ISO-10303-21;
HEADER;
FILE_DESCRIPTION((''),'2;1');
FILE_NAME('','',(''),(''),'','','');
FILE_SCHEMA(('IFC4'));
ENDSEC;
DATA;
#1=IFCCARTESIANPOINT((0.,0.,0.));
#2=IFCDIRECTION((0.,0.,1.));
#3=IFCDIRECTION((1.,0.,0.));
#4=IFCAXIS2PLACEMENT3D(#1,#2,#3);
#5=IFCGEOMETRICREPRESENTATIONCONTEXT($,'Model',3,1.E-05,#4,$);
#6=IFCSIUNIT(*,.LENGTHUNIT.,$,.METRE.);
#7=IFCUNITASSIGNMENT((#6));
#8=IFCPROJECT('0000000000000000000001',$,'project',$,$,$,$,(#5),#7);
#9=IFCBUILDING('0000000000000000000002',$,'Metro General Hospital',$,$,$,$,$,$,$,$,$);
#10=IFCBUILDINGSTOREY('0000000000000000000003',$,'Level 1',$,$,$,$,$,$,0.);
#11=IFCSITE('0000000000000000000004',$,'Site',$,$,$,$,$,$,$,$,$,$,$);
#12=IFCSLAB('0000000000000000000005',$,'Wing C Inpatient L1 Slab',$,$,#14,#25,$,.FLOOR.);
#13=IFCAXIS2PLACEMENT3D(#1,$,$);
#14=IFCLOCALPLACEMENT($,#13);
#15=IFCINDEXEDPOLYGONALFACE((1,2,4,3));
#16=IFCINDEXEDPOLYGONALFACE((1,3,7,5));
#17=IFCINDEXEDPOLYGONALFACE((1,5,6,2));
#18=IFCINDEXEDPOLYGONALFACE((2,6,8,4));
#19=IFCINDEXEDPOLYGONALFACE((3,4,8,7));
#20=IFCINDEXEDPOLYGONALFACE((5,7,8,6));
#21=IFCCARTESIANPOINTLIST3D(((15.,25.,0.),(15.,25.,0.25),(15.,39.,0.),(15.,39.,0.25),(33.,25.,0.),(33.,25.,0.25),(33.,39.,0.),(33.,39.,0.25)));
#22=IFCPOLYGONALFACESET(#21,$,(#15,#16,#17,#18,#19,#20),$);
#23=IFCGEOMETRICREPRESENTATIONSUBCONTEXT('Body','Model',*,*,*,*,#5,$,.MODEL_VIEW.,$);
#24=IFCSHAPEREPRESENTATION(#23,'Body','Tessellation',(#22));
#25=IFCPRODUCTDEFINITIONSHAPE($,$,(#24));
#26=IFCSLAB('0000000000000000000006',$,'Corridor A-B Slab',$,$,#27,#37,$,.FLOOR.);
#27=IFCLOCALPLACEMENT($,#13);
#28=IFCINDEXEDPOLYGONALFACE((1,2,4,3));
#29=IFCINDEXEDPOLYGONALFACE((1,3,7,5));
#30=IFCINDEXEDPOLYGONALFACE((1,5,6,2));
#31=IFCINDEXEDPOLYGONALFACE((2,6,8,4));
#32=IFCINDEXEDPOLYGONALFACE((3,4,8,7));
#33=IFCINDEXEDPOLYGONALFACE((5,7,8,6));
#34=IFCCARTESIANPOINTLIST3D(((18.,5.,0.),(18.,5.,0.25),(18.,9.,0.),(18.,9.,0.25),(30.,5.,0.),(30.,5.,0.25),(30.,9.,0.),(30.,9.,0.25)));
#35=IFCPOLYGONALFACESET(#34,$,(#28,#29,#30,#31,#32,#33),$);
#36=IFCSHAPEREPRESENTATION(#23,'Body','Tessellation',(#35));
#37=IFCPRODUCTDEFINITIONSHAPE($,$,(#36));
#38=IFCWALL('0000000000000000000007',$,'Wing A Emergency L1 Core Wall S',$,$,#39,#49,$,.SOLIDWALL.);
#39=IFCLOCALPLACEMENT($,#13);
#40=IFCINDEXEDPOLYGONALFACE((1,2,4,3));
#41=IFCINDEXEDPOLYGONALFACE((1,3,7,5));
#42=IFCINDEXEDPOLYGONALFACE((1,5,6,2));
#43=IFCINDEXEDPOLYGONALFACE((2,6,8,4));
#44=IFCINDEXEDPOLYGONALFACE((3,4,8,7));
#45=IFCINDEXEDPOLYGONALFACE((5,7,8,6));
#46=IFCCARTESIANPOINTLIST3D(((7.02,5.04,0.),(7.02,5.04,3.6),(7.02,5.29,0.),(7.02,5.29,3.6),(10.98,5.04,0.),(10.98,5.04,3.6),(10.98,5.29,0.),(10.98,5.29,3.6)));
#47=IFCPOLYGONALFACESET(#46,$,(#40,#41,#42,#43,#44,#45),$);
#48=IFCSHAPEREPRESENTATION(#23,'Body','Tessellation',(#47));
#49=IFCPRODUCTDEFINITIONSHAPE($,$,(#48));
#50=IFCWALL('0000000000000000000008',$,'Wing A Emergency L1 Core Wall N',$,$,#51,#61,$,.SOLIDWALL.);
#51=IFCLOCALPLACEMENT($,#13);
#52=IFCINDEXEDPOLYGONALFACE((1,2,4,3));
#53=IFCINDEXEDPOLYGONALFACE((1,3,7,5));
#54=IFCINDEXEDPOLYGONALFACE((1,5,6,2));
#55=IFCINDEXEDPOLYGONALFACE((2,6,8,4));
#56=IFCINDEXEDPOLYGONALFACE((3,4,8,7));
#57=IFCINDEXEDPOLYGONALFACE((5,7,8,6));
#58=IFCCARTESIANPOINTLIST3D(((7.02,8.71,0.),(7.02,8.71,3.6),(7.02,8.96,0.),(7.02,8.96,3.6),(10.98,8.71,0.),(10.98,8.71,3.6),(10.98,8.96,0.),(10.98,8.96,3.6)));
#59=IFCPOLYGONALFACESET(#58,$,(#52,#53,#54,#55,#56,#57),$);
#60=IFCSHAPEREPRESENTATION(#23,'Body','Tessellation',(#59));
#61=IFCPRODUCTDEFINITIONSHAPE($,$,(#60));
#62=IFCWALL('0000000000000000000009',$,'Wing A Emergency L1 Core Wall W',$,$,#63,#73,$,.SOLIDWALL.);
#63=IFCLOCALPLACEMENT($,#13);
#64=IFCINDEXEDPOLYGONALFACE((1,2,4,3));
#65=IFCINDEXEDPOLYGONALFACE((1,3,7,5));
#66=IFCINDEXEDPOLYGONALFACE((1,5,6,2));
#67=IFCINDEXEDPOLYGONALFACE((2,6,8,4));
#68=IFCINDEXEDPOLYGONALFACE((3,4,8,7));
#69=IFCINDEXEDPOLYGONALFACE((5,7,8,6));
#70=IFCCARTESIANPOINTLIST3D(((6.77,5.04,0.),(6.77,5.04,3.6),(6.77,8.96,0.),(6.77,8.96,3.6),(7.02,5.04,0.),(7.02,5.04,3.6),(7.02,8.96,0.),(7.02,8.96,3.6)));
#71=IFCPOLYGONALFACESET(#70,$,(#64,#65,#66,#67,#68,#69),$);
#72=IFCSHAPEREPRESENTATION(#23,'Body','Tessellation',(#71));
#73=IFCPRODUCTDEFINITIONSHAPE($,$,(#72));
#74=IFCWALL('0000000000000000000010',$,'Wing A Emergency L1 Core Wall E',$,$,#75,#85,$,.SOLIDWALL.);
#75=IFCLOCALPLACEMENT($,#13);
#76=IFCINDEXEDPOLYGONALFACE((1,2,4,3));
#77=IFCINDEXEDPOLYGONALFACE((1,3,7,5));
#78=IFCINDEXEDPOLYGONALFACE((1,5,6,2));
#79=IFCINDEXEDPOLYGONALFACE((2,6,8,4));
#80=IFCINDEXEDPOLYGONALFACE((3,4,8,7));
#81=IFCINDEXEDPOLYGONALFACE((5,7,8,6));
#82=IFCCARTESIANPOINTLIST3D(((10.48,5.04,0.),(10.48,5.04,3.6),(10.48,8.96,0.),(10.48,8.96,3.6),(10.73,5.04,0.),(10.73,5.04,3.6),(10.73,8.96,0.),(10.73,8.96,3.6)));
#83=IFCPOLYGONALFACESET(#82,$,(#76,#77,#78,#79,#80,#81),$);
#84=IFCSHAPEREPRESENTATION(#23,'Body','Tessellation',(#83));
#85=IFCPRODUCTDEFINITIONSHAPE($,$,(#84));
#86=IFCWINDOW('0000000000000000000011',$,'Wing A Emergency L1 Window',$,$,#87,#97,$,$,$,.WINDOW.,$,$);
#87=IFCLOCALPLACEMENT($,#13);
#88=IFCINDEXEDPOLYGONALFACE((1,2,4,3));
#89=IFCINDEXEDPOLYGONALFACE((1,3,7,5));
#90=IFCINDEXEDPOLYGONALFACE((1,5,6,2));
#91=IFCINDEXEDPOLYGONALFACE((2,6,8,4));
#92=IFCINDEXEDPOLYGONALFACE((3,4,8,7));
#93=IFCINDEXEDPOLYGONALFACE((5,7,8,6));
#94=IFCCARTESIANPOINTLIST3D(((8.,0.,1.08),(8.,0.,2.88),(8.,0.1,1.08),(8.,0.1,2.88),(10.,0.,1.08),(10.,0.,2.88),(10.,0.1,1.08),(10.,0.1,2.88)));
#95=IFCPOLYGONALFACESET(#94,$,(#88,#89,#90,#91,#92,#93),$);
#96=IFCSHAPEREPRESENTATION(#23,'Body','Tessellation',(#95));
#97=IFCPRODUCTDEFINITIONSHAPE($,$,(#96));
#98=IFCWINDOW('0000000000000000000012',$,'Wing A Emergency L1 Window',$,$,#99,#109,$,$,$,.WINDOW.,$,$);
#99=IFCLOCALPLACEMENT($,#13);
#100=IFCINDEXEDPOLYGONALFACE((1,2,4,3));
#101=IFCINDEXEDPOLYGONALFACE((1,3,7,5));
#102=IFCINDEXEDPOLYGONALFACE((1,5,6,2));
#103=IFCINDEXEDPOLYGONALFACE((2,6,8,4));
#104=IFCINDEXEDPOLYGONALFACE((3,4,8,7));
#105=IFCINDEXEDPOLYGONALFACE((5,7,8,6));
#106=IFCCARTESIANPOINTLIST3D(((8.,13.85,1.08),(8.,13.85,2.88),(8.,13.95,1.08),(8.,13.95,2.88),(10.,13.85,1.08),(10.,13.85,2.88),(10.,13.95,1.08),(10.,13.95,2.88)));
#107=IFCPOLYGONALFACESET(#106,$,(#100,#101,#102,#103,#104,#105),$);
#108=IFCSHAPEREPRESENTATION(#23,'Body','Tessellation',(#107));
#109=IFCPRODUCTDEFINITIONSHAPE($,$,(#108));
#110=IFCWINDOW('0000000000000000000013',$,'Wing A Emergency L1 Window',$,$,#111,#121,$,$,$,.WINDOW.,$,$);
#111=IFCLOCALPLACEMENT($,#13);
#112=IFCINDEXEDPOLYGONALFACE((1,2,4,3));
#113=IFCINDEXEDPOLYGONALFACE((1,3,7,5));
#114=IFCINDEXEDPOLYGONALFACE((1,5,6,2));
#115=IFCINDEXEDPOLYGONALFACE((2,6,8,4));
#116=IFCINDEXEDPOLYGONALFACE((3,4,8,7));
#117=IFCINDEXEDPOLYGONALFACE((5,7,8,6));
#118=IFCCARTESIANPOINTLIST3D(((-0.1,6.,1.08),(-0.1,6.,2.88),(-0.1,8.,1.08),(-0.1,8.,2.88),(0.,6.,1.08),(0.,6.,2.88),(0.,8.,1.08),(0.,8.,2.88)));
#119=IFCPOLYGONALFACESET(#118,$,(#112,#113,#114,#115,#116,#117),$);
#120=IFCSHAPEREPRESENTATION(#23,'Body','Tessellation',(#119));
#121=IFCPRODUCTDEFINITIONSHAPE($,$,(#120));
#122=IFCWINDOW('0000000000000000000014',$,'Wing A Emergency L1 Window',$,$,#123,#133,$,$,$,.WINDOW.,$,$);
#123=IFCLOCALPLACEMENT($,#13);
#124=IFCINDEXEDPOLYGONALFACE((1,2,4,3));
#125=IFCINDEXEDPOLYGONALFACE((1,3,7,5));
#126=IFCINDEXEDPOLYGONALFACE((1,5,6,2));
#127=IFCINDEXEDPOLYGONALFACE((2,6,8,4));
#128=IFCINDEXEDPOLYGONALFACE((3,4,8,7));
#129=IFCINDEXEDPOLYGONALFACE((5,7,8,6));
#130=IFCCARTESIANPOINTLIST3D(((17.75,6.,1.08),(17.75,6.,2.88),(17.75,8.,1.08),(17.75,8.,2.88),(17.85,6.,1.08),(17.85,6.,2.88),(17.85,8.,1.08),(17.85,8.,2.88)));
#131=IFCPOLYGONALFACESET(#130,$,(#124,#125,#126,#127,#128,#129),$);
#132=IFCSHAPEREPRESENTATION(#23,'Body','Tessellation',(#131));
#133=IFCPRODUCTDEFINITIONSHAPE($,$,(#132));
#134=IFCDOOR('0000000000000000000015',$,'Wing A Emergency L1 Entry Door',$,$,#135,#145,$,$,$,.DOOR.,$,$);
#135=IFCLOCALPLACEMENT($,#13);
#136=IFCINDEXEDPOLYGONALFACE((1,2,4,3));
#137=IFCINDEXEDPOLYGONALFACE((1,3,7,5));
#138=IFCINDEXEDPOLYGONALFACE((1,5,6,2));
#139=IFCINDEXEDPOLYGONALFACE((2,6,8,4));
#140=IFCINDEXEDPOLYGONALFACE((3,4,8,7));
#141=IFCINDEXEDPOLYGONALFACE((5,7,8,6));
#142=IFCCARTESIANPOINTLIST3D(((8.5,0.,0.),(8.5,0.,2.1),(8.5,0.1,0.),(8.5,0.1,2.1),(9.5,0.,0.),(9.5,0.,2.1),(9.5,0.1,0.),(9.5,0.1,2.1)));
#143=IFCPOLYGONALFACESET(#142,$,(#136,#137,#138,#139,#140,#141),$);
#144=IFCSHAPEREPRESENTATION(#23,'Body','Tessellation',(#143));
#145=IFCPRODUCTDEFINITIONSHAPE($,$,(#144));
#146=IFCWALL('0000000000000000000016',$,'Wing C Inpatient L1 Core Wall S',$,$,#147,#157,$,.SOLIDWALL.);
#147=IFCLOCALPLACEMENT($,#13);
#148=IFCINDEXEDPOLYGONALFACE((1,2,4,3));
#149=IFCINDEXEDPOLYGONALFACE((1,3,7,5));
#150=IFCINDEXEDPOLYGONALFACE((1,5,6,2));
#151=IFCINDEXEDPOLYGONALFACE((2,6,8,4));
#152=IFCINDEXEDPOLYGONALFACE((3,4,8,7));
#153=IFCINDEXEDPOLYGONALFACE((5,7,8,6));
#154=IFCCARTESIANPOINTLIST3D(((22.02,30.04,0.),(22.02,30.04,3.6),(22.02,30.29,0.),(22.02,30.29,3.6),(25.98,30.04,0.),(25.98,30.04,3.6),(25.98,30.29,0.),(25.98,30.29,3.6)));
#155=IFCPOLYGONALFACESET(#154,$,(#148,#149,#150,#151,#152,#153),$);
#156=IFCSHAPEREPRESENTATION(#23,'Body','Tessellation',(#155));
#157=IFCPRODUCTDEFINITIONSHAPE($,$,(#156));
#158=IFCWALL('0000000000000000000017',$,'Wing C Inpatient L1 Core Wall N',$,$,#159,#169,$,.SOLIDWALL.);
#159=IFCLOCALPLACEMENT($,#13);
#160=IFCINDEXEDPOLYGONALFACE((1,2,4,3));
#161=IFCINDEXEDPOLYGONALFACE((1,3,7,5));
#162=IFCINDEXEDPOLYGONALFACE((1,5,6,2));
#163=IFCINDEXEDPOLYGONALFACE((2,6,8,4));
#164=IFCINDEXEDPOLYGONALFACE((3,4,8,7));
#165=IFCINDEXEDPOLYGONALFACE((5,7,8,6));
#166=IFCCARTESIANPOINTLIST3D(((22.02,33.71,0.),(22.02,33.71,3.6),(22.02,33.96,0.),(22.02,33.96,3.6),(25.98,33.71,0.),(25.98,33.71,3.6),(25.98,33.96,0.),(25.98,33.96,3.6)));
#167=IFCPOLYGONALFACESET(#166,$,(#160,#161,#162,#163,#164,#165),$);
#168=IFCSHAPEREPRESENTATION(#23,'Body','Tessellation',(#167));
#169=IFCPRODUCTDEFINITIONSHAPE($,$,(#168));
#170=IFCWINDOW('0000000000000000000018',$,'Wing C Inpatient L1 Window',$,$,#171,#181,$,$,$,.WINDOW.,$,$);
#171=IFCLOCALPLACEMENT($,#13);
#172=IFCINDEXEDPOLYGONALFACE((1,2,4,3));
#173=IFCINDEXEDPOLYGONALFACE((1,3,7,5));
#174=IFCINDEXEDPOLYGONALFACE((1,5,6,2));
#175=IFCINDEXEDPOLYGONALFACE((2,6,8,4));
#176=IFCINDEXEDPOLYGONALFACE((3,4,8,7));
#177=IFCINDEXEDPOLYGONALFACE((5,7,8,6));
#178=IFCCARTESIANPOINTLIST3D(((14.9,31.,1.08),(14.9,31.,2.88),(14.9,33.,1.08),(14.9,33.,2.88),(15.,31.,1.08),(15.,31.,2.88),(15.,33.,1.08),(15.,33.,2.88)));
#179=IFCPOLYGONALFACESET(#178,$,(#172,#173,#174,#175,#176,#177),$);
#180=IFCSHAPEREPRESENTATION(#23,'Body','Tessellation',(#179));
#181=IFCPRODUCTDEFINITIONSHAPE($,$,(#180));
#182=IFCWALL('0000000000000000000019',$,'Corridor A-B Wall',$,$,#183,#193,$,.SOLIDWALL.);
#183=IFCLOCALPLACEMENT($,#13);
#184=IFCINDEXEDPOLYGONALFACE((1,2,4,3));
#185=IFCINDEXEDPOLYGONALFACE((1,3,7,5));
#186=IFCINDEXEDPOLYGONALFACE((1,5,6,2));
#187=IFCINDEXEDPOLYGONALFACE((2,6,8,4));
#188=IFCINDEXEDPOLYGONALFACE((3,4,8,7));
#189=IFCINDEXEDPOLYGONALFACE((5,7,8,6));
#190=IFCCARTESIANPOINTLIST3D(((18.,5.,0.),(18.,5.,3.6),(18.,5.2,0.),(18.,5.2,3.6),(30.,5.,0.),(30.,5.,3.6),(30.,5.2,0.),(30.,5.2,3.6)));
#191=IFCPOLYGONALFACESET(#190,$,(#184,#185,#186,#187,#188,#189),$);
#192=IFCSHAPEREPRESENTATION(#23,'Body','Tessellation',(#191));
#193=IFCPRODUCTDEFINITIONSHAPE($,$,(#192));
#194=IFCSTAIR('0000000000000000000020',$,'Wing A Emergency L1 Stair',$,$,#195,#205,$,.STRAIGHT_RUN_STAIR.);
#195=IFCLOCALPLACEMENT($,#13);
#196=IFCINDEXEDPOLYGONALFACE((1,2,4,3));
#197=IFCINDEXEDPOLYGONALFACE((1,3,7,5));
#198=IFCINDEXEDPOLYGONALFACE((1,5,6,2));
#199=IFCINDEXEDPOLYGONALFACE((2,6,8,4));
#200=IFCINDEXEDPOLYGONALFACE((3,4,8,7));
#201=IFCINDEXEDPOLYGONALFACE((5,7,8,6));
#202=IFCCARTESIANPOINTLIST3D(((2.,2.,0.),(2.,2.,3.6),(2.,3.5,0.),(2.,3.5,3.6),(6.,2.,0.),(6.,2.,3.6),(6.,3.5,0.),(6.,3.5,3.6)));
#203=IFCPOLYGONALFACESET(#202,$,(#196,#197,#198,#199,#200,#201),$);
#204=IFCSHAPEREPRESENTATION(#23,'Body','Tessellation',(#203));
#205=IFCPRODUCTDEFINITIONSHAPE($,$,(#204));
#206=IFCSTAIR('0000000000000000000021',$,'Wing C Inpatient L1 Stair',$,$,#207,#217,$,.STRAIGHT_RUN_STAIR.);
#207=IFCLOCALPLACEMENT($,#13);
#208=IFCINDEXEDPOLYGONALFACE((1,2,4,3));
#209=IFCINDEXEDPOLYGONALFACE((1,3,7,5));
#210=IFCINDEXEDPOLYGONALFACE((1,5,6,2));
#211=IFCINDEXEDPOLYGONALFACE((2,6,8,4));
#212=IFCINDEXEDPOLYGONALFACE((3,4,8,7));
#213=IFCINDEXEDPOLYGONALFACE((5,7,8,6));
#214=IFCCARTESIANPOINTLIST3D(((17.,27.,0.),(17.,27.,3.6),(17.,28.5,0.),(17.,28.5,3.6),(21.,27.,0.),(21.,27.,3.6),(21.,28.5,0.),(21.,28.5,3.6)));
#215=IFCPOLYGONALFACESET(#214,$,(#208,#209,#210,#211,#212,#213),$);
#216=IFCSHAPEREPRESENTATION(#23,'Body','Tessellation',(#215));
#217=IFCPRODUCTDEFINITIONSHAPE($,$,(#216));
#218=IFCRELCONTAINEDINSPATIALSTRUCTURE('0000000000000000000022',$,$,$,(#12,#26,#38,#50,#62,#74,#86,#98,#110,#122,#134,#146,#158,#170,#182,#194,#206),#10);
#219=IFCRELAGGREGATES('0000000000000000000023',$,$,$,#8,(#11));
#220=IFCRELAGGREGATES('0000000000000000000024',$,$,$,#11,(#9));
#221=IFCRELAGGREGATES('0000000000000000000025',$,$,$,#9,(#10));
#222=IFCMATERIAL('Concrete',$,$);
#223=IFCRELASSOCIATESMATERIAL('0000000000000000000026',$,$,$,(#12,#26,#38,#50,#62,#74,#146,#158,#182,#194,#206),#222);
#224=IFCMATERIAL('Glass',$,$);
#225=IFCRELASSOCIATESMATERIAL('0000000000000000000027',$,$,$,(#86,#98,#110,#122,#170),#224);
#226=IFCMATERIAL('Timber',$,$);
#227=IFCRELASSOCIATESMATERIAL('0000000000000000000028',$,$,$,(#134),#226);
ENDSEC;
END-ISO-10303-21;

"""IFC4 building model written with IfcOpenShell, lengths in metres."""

from ifc_helpers import new_model, si_unit, frame, origin_with_axes, place, context, subcontext, project, spatial, line, indexed_curve, outline, extrude, material, element, save


model = new_model("IFC4")

# Units and contexts
model_context = context("Model", 3, precision=1e-05, world=origin_with_axes())
body_context = subcontext(model_context, "Body", "Model", "MODEL_VIEW")
ifc_project = project(units=[si_unit("LENGTHUNIT", "METRE")], contexts=[model_context])

# Site, building, storey
site = spatial("IfcSite", under=ifc_project, Name="Site")
building = spatial("IfcBuilding", under=site, Name="Metro General Hospital")
storey = spatial("IfcBuildingStorey", under=building, Name="Level 1", Elevation=0.0)

# Slabs
ifc_material_1 = material(Name="Concrete")
for number, where, z_axis, x_axis, name in (
    (1, (15.0, 25.0, 0.0), (0.0, 0.0, 1.0), (1.0, 0.0, 0.0), "Wing C Inpatient L1 Slab"),
):
    element("IfcSlab", number, at=place(None, frame(where, z_axis=z_axis, x_axis=x_axis)), inside=storey, material=ifc_material_1, Name=name, PredefinedType="FLOOR", context=body_context, shape_type="SweptSolid", body=[
        extrude(outline(indexed_curve([(0.0, 0.0), (18.0, 0.0), (18.0, 14.0), (0.0, 14.0)], segments=[line(1, 2, 3, 4, 1)])), origin_with_axes(), (0.0, 0.0, 1.0), 0.25),
    ])
slab_placement = place(None, frame((18.0, 5.0, 0.0), z_axis=(0.0, 0.0, 1.0), x_axis=(1.0, 0.0, 0.0)))
element("IfcSlab", 2, at=slab_placement, inside=storey, material=ifc_material_1, Name="Corridor A-B Slab", PredefinedType="FLOOR", context=body_context, shape_type="SweptSolid", body=[
    extrude(outline(indexed_curve([(0.0, 0.0), (12.0, 0.0), (12.0, 4.0), (0.0, 4.0)], segments=[line(1, 2, 3, 4, 1)])), origin_with_axes(), (0.0, 0.0, 1.0), 0.25),
])

# Walls
for number, where, z_axis, x_axis, name in (
    (3, (7.02, 5.04, 0.0), (0.0, 0.0, 1.0), (1.0, 0.0, 0.0), "Wing A Emergency L1 Core Wall S"),
    (4, (7.02, 8.71, 0.0), (0.0, 0.0, 1.0), (1.0, 0.0, 0.0), "Wing A Emergency L1 Core Wall N"),
):
    element("IfcWall", number, at=place(None, frame(where, z_axis=z_axis, x_axis=x_axis)), inside=storey, material=ifc_material_1, Name=name, PredefinedType="SOLIDWALL", context=body_context, shape_type="SweptSolid", body=[
        extrude(outline(indexed_curve([(0.0, 0.0), (3.96, 0.0), (3.96, 0.25), (0.0, 0.25)], segments=[line(1, 2, 3, 4, 1)])), origin_with_axes(), (0.0, 0.0, 1.0), 3.6),
    ])
for number, where, z_axis, x_axis, name in (
    (5, (7.02, 5.04, 0.0), (0.0, 0.0, 1.0), (0.0, 1.0, 0.0), "Wing A Emergency L1 Core Wall W"),
    (6, (10.73, 5.04, 0.0), (0.0, 0.0, 1.0), (0.0, 1.0, 0.0), "Wing A Emergency L1 Core Wall E"),
):
    element("IfcWall", number, at=place(None, frame(where, z_axis=z_axis, x_axis=x_axis)), inside=storey, material=ifc_material_1, Name=name, PredefinedType="SOLIDWALL", context=body_context, shape_type="SweptSolid", body=[
        extrude(outline(indexed_curve([(0.0, 0.0), (3.92, 0.0), (3.92, 0.25), (0.0, 0.25)], segments=[line(1, 2, 3, 4, 1)])), origin_with_axes(), (0.0, 0.0, 1.0), 3.6),
    ])

# Windows
ifc_material_2 = material(Name="Glass")
for number, where, z_axis, x_axis, name in (
    (7, (8.0, 0.0, 1.08), (0.0, 0.0, 1.0), (1.0, 0.0, 0.0), "Wing A Emergency L1 Window"),
    (8, (8.0, 13.85, 1.08), (0.0, 0.0, 1.0), (1.0, 0.0, 0.0), "Wing A Emergency L1 Window"),
    (9, (0.0, 6.0, 1.08), (0.0, 0.0, 1.0), (0.0, 1.0, 0.0), "Wing A Emergency L1 Window"),
    (10, (17.85, 6.0, 1.08), (0.0, 0.0, 1.0), (0.0, 1.0, 0.0), "Wing A Emergency L1 Window"),
):
    element("IfcWindow", number, at=place(None, frame(where, z_axis=z_axis, x_axis=x_axis)), inside=storey, material=ifc_material_2, Name=name, PredefinedType="WINDOW", context=body_context, shape_type="SweptSolid", body=[
        extrude(outline(indexed_curve([(0.0, 0.0), (2.0, 0.0), (2.0, 0.1), (0.0, 0.1)], segments=[line(1, 2, 3, 4, 1)])), origin_with_axes(), (0.0, 0.0, 1.0), 1.8),
    ])

# Door
ifc_material_3 = material(Name="Timber")
door_placement = place(None, frame((8.5, 0.0, 0.0), z_axis=(0.0, 0.0, 1.0), x_axis=(1.0, 0.0, 0.0)))
element("IfcDoor", 11, at=door_placement, inside=storey, material=ifc_material_3, Name="Wing A Emergency L1 Entry Door", PredefinedType="DOOR", context=body_context, shape_type="SweptSolid", body=[
    extrude(outline(indexed_curve([(0.0, 0.0), (1.0, 0.0), (1.0, 0.1), (0.0, 0.1)], segments=[line(1, 2, 3, 4, 1)])), origin_with_axes(), (0.0, 0.0, 1.0), 2.1),
])

# Walls
for number, where, z_axis, x_axis, name in (
    (12, (22.02, 30.04, 0.0), (0.0, 0.0, 1.0), (1.0, 0.0, 0.0), "Wing C Inpatient L1 Core Wall S"),
    (13, (22.02, 33.71, 0.0), (0.0, 0.0, 1.0), (1.0, 0.0, 0.0), "Wing C Inpatient L1 Core Wall N"),
):
    element("IfcWall", number, at=place(None, frame(where, z_axis=z_axis, x_axis=x_axis)), inside=storey, material=ifc_material_1, Name=name, PredefinedType="SOLIDWALL", context=body_context, shape_type="SweptSolid", body=[
        extrude(outline(indexed_curve([(0.0, 0.0), (3.96, 0.0), (3.96, 0.25), (0.0, 0.25)], segments=[line(1, 2, 3, 4, 1)])), origin_with_axes(), (0.0, 0.0, 1.0), 3.6),
    ])

# Window
window_placement = place(None, frame((15.0, 31.0, 1.08), z_axis=(0.0, 0.0, 1.0), x_axis=(0.0, 1.0, 0.0)))
element("IfcWindow", 14, at=window_placement, inside=storey, material=ifc_material_2, Name="Wing C Inpatient L1 Window", PredefinedType="WINDOW", context=body_context, shape_type="SweptSolid", body=[
    extrude(outline(indexed_curve([(0.0, 0.0), (2.0, 0.0), (2.0, 0.1), (0.0, 0.1)], segments=[line(1, 2, 3, 4, 1)])), origin_with_axes(), (0.0, 0.0, 1.0), 1.8),
])

# Wall
wall_placement = place(None, frame((18.0, 5.0, 0.0), z_axis=(0.0, 0.0, 1.0), x_axis=(1.0, 0.0, 0.0)))
element("IfcWall", 15, at=wall_placement, inside=storey, material=ifc_material_1, Name="Corridor A-B Wall", PredefinedType="SOLIDWALL", context=body_context, shape_type="SweptSolid", body=[
    extrude(outline(indexed_curve([(0.0, 0.0), (12.0, 0.0), (12.0, 0.2), (0.0, 0.2)], segments=[line(1, 2, 3, 4, 1)])), origin_with_axes(), (0.0, 0.0, 1.0), 3.6),
])

# Stairs
for number, where, z_axis, x_axis, name in (
    (16, (2.0, 2.0, 0.0), (0.0, 0.0, 1.0), (1.0, 0.0, 0.0), "Wing A Emergency L1 Stair"),
    (17, (17.0, 27.0, 0.0), (0.0, 0.0, 1.0), (1.0, 0.0, 0.0), "Wing C Inpatient L1 Stair"),
):
    element("IfcStair", number, at=place(None, frame(where, z_axis=z_axis, x_axis=x_axis)), inside=storey, material=ifc_material_1, Name=name, PredefinedType="STRAIGHT_RUN_STAIR", context=body_context, shape_type="SweptSolid", body=[
        extrude(outline(indexed_curve([(0.0, 0.0), (4.0, 0.0), (4.0, 1.5), (0.0, 1.5)], segments=[line(1, 2, 3, 4, 1)])), origin_with_axes(), (0.0, 0.0, 1.0), 3.6),
    ])

save(model, "model.ifc")
